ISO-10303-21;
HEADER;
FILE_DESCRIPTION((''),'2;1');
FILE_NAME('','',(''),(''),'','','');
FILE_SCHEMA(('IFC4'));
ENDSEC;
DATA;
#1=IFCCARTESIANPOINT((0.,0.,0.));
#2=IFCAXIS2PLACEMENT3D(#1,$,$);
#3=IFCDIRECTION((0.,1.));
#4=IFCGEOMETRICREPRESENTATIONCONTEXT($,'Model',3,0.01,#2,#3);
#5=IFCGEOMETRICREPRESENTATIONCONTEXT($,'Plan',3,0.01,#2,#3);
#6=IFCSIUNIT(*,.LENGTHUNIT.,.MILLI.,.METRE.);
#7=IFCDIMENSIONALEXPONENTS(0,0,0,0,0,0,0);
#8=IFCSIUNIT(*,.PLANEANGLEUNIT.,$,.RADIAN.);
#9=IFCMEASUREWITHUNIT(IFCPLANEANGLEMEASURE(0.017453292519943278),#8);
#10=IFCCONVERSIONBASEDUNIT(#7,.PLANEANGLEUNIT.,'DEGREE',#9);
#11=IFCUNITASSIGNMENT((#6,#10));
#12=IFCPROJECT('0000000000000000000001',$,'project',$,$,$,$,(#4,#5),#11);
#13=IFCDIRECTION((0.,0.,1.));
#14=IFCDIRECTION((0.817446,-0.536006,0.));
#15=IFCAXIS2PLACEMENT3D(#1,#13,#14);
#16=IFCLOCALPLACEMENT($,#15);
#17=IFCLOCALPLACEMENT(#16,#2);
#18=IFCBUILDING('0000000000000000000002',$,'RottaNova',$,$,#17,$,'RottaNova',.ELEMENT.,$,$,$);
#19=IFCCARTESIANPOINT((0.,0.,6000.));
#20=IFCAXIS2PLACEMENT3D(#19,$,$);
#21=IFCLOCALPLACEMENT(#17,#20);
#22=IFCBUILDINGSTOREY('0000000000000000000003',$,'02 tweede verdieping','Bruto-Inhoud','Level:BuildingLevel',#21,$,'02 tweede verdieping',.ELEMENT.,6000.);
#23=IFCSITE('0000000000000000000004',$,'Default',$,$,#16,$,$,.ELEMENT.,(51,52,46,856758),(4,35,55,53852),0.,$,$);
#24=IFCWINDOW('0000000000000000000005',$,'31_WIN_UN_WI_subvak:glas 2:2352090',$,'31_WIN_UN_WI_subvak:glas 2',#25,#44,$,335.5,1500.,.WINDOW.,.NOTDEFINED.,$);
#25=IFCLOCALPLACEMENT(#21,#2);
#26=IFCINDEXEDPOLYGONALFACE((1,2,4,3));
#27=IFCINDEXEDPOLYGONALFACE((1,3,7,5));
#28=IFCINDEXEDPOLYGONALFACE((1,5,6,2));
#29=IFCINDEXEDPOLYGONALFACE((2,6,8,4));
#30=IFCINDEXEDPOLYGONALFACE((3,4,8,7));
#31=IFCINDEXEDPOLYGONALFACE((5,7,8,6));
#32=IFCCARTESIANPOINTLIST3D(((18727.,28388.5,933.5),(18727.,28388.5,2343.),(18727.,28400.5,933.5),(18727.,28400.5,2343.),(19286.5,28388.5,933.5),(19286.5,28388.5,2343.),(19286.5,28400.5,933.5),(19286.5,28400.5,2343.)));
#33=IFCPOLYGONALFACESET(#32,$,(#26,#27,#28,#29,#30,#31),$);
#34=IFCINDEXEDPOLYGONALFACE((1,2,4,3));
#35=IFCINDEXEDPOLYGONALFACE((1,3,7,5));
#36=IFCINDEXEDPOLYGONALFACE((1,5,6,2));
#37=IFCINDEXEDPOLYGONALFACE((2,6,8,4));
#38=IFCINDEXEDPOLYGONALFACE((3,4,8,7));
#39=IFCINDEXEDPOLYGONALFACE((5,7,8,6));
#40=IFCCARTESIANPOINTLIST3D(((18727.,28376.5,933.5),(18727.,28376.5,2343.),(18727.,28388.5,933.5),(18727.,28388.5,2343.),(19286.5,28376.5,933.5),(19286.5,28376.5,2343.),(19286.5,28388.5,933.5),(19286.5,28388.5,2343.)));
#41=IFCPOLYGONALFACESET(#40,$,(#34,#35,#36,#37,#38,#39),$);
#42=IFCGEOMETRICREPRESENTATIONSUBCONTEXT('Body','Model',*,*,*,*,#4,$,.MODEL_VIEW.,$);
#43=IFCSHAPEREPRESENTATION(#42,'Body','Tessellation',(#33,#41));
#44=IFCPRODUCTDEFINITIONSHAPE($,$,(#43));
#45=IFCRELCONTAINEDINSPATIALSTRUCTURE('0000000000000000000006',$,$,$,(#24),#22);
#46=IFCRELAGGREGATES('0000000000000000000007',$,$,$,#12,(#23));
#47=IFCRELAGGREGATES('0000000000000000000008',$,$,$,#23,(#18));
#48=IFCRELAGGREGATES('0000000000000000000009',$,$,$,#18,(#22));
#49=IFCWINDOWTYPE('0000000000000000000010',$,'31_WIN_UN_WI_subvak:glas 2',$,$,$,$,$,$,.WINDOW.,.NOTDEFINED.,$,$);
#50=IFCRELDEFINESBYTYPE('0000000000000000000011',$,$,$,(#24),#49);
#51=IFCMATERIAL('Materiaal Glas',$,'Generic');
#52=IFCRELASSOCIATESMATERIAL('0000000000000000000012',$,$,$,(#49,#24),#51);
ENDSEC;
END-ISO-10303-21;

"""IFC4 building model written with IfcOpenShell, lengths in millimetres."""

from ifc_helpers import new_model, entity, si_unit, converted_unit, direction, frame, origin, place, context, subcontext, project, spatial, indexed_curve, outline, extrude, source, transform, mapped, material, type_object, type_shapes, element, save


model = new_model("IFC4")

# Units and contexts
model_context = context("Model", 3, precision=0.01, world=origin(), true_north=direction((0.0, 1.0)))
plan_context = context("Plan", 3, precision=0.01, world=origin(), true_north=direction((0.0, 1.0)))
body_context = subcontext(model_context, "Body", "Model", "MODEL_VIEW")
ifc_project = project(units=[si_unit("LENGTHUNIT", "METRE", prefix="MILLI"), converted_unit("PLANEANGLEUNIT", "DEGREE", entity("IfcPlaneAngleMeasure", 0.017453292519943278), si_unit("PLANEANGLEUNIT", "RADIAN"), dimensions=[0, 0, 0, 0, 0, 0, 0])], contexts=[model_context, plan_context])

# Site, building, storey
site_placement = place(None, frame((0.0, 0.0, 0.0), z_axis=(0.0, 0.0, 1.0), x_axis=(0.817446, -0.536006, 0.0)))
site = spatial("IfcSite", under=ifc_project, at=site_placement, Name="Default", CompositionType="ELEMENT", RefLatitude=(51, 52, 46, 856758), RefLongitude=(4, 35, 55, 53852), RefElevation=0.0)
building_placement = place(site_placement, origin())
building = spatial("IfcBuilding", under=site, at=building_placement, Name="RottaNova", LongName="RottaNova", CompositionType="ELEMENT")
storey_placement = place(building_placement, frame((0.0, 0.0, 6000.0)))
storey = spatial("IfcBuildingStorey", under=building, at=storey_placement, Name="02 tweede verdieping", Description="Bruto-Inhoud", ObjectType="Level:BuildingLevel", LongName="02 tweede verdieping", CompositionType="ELEMENT", Elevation=6000.0)

# Shared definitions
ifc_material_1 = material(Name="Materiaal Glas", Category="Generic")

# Window
window_type_1 = type_object("IfcWindowType", Name="31_WIN_UN_WI_subvak:glas 2", PartitioningType="NOTDEFINED", PredefinedType="WINDOW", material=ifc_material_1)
shared_shape_1 = source(origin(), body_context, "Body", "SweptSolid", [
    extrude(outline(indexed_curve([(-6.0, -279.8), (6.0, -279.8), (6.0, 279.8), (-6.0, 279.8), (-6.0, -279.8)], self_intersect=False)), frame((0.0, 6.0, 0.0), z_axis=(0.0, 0.0, 1.0), x_axis=(0.0, -1.0, 0.0)), (0.0, 0.0, 1.0), 1409.5),
    extrude(outline(indexed_curve([(-6.0, -279.8), (6.0, -279.8), (6.0, 279.8), (-6.0, 279.8), (-6.0, -279.8)], self_intersect=False)), frame((0.0, -6.0, 0.0), z_axis=(0.0, 0.0, 1.0), x_axis=(0.0, -1.0, 0.0)), (0.0, 0.0, 1.0), 1409.5),
])
type_shapes(window_type_1, [shared_shape_1])
window_1_placement = place(storey_placement, frame((19006.8, 28388.5, 933.5)))
element("IfcWindow", 1, at=window_1_placement, inside=storey, type_object=window_type_1, material=ifc_material_1, Name="31_WIN_UN_WI_subvak:glas 2:2352090", ObjectType="31_WIN_UN_WI_subvak:glas 2", OverallHeight=335.5, OverallWidth=1500.0, PartitioningType="NOTDEFINED", PredefinedType="WINDOW", context=body_context, shape_type="MappedRepresentation", body=[
    mapped(shared_shape_1, transform((0.0, 0.0, 0.0), scale=1.0)),
])

save(model, "model.ifc")
